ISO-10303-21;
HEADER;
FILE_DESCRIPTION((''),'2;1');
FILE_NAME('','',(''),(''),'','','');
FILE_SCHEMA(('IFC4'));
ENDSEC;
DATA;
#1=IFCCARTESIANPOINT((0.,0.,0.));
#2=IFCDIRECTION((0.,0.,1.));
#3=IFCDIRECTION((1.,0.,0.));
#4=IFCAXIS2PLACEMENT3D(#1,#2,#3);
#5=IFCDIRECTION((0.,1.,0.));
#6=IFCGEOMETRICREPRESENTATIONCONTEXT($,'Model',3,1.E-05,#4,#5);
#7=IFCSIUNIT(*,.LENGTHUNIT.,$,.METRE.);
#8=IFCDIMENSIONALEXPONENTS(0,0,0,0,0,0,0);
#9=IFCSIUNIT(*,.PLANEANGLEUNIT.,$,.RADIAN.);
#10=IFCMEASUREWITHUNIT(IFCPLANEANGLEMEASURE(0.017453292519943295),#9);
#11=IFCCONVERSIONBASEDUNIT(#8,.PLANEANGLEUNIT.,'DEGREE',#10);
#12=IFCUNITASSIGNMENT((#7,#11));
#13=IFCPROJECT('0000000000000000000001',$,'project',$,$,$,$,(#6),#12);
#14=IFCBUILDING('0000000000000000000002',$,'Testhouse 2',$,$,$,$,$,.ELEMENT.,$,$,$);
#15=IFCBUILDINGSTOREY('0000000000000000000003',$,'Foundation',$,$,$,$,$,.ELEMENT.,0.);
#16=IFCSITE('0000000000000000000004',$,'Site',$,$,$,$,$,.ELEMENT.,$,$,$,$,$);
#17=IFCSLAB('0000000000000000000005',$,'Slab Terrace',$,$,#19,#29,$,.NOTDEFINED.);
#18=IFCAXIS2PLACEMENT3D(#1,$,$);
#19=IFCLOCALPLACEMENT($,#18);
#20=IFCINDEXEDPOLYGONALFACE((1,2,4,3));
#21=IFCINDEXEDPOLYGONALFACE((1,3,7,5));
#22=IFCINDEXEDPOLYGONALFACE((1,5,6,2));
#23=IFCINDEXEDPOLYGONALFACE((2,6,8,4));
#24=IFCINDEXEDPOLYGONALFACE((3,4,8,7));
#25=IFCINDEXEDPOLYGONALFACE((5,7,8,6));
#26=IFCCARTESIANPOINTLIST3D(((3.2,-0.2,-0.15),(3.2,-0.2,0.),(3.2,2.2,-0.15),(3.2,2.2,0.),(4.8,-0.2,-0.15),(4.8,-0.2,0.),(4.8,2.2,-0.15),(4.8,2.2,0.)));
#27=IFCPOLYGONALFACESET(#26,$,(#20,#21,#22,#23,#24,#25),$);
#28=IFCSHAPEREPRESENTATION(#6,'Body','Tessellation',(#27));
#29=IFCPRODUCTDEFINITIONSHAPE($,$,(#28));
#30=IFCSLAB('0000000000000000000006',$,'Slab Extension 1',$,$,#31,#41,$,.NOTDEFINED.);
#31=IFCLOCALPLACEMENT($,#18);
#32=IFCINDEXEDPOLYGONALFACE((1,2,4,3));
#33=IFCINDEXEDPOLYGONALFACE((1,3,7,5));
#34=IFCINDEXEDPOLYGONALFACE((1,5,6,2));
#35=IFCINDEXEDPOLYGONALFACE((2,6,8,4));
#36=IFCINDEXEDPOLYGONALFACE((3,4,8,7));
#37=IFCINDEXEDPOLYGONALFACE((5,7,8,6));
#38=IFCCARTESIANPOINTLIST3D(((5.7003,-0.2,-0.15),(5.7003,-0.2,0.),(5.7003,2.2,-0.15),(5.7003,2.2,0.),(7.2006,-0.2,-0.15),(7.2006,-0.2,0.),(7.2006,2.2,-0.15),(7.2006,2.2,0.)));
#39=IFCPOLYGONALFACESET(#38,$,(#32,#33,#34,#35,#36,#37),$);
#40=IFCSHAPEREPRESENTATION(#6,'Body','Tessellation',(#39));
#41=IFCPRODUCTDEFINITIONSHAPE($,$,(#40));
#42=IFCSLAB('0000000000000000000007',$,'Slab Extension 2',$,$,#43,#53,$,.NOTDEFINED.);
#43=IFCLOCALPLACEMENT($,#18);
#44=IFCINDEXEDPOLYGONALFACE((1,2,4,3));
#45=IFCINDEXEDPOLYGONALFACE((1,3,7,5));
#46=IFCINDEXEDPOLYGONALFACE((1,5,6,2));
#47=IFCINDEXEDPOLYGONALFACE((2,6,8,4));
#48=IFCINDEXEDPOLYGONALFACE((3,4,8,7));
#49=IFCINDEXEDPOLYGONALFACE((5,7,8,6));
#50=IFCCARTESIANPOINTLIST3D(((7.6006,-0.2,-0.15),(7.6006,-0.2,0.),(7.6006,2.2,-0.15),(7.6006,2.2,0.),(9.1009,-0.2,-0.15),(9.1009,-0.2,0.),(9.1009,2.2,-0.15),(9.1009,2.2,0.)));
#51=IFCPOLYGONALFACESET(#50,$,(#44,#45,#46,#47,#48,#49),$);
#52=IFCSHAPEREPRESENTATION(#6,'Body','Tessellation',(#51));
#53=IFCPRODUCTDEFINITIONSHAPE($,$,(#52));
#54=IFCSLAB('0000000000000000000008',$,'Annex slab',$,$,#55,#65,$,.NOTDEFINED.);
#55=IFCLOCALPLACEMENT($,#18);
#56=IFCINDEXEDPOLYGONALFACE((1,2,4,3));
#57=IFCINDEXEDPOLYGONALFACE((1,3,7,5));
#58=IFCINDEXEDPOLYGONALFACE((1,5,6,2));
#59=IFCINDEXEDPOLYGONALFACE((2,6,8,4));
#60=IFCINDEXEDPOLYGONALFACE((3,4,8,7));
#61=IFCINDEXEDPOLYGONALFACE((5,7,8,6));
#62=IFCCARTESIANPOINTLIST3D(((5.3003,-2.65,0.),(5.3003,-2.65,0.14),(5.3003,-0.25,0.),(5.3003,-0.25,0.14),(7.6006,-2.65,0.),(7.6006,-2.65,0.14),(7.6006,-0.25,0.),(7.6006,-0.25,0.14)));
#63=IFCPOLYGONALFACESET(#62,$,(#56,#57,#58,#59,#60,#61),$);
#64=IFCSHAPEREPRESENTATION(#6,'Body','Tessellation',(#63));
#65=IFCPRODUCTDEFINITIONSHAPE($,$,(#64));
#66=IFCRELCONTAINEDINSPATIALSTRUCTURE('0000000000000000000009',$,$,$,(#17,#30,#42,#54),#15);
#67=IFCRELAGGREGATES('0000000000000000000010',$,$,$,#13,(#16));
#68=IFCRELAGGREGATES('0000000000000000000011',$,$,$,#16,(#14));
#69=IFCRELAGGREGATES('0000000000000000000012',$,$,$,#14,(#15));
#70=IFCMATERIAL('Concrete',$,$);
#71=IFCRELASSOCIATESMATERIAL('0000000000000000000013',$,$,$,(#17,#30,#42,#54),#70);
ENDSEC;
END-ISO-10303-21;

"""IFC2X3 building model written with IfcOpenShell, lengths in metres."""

from ifc_helpers import new_model, entity, si_unit, converted_unit, direction, frame, origin_with_axes, place, context, project, spatial, polyline, outline, extrude, material, element, save


model = new_model("IFC2X3")

# Units and contexts
model_context = context("Model", 3, precision=1e-05, world=origin_with_axes(), true_north=direction((0.0, 1.0, 0.0)))
ifc_project = project(units=[si_unit("LENGTHUNIT", "METRE"), converted_unit("PLANEANGLEUNIT", "DEGREE", entity("IfcPlaneAngleMeasure", 0.017453292519943295), si_unit("PLANEANGLEUNIT", "RADIAN"), dimensions=[0, 0, 0, 0, 0, 0, 0])], contexts=[model_context])

# Site, building, storey
site = spatial("IfcSite", under=ifc_project, Name="Site", CompositionType="ELEMENT")
building = spatial("IfcBuilding", under=site, Name="Testhouse 2", CompositionType="ELEMENT")
storey = spatial("IfcBuildingStorey", under=building, Name="Foundation", CompositionType="ELEMENT", Elevation=0.0)

# Shared definitions
ifc_material = material(Name="Concrete")

# Slabs
slab_1_placement = place(None, origin_with_axes())
element("IfcSlab", 1, at=slab_1_placement, inside=storey, material=ifc_material, Name="Slab Terrace", PredefinedType="NOTDEFINED", context=model_context, shape_type="SweptSolid", body=[
    extrude(outline(polyline([(0.0, 0.0), (-1.6, 0.0), (-1.6, 2.4), (0.0, 2.4), (0.0, 0.0)])), frame((4.8, -0.2, -0.15), z_axis=(0.0, 0.0, 1.0), x_axis=(1.0, 0.0, 0.0)), (0.0, 0.0, 1.0), 0.15),
])
slab_2_placement = place(None, origin_with_axes())
element("IfcSlab", 2, at=slab_2_placement, inside=storey, material=ifc_material, Name="Slab Extension 1", PredefinedType="NOTDEFINED", context=model_context, shape_type="SweptSolid", body=[
    extrude(outline(polyline([(0.0, 0.0), (1.5003, 0.0), (1.5003, -2.4), (0.0, -2.4), (0.0, 0.0)])), frame((5.7003, 2.2, -0.15), z_axis=(0.0, 0.0, 1.0), x_axis=(1.0, 0.0, 0.0)), (0.0, 0.0, 1.0), 0.15),
])
slab_3_placement = place(None, origin_with_axes())
element("IfcSlab", 3, at=slab_3_placement, inside=storey, material=ifc_material, Name="Slab Extension 2", PredefinedType="NOTDEFINED", context=model_context, shape_type="SweptSolid", body=[
    extrude(outline(polyline([(0.0, 0.0), (1.5003, 0.0), (1.5003, -2.4), (0.0, -2.4), (0.0, 0.0)])), frame((7.6006, 2.2, -0.15), z_axis=(0.0, 0.0, 1.0), x_axis=(1.0, 0.0, 0.0)), (0.0, 0.0, 1.0), 0.15),
])
slab_4_placement = place(None, origin_with_axes())
element("IfcSlab", 4, at=slab_4_placement, inside=storey, material=ifc_material, Name="Annex slab", PredefinedType="NOTDEFINED", context=model_context, shape_type="SweptSolid", body=[
    extrude(outline(polyline([(0.0, 0.0), (2.3003, 0.0), (2.3003, -2.4), (0.0, -2.4), (0.0, 0.0)])), frame((5.3003, -0.25, 0.0), z_axis=(0.0, 0.0, 1.0), x_axis=(1.0, 0.0, 0.0)), (0.0, 0.0, 1.0), 0.14),
])

save(model, "model.ifc")
